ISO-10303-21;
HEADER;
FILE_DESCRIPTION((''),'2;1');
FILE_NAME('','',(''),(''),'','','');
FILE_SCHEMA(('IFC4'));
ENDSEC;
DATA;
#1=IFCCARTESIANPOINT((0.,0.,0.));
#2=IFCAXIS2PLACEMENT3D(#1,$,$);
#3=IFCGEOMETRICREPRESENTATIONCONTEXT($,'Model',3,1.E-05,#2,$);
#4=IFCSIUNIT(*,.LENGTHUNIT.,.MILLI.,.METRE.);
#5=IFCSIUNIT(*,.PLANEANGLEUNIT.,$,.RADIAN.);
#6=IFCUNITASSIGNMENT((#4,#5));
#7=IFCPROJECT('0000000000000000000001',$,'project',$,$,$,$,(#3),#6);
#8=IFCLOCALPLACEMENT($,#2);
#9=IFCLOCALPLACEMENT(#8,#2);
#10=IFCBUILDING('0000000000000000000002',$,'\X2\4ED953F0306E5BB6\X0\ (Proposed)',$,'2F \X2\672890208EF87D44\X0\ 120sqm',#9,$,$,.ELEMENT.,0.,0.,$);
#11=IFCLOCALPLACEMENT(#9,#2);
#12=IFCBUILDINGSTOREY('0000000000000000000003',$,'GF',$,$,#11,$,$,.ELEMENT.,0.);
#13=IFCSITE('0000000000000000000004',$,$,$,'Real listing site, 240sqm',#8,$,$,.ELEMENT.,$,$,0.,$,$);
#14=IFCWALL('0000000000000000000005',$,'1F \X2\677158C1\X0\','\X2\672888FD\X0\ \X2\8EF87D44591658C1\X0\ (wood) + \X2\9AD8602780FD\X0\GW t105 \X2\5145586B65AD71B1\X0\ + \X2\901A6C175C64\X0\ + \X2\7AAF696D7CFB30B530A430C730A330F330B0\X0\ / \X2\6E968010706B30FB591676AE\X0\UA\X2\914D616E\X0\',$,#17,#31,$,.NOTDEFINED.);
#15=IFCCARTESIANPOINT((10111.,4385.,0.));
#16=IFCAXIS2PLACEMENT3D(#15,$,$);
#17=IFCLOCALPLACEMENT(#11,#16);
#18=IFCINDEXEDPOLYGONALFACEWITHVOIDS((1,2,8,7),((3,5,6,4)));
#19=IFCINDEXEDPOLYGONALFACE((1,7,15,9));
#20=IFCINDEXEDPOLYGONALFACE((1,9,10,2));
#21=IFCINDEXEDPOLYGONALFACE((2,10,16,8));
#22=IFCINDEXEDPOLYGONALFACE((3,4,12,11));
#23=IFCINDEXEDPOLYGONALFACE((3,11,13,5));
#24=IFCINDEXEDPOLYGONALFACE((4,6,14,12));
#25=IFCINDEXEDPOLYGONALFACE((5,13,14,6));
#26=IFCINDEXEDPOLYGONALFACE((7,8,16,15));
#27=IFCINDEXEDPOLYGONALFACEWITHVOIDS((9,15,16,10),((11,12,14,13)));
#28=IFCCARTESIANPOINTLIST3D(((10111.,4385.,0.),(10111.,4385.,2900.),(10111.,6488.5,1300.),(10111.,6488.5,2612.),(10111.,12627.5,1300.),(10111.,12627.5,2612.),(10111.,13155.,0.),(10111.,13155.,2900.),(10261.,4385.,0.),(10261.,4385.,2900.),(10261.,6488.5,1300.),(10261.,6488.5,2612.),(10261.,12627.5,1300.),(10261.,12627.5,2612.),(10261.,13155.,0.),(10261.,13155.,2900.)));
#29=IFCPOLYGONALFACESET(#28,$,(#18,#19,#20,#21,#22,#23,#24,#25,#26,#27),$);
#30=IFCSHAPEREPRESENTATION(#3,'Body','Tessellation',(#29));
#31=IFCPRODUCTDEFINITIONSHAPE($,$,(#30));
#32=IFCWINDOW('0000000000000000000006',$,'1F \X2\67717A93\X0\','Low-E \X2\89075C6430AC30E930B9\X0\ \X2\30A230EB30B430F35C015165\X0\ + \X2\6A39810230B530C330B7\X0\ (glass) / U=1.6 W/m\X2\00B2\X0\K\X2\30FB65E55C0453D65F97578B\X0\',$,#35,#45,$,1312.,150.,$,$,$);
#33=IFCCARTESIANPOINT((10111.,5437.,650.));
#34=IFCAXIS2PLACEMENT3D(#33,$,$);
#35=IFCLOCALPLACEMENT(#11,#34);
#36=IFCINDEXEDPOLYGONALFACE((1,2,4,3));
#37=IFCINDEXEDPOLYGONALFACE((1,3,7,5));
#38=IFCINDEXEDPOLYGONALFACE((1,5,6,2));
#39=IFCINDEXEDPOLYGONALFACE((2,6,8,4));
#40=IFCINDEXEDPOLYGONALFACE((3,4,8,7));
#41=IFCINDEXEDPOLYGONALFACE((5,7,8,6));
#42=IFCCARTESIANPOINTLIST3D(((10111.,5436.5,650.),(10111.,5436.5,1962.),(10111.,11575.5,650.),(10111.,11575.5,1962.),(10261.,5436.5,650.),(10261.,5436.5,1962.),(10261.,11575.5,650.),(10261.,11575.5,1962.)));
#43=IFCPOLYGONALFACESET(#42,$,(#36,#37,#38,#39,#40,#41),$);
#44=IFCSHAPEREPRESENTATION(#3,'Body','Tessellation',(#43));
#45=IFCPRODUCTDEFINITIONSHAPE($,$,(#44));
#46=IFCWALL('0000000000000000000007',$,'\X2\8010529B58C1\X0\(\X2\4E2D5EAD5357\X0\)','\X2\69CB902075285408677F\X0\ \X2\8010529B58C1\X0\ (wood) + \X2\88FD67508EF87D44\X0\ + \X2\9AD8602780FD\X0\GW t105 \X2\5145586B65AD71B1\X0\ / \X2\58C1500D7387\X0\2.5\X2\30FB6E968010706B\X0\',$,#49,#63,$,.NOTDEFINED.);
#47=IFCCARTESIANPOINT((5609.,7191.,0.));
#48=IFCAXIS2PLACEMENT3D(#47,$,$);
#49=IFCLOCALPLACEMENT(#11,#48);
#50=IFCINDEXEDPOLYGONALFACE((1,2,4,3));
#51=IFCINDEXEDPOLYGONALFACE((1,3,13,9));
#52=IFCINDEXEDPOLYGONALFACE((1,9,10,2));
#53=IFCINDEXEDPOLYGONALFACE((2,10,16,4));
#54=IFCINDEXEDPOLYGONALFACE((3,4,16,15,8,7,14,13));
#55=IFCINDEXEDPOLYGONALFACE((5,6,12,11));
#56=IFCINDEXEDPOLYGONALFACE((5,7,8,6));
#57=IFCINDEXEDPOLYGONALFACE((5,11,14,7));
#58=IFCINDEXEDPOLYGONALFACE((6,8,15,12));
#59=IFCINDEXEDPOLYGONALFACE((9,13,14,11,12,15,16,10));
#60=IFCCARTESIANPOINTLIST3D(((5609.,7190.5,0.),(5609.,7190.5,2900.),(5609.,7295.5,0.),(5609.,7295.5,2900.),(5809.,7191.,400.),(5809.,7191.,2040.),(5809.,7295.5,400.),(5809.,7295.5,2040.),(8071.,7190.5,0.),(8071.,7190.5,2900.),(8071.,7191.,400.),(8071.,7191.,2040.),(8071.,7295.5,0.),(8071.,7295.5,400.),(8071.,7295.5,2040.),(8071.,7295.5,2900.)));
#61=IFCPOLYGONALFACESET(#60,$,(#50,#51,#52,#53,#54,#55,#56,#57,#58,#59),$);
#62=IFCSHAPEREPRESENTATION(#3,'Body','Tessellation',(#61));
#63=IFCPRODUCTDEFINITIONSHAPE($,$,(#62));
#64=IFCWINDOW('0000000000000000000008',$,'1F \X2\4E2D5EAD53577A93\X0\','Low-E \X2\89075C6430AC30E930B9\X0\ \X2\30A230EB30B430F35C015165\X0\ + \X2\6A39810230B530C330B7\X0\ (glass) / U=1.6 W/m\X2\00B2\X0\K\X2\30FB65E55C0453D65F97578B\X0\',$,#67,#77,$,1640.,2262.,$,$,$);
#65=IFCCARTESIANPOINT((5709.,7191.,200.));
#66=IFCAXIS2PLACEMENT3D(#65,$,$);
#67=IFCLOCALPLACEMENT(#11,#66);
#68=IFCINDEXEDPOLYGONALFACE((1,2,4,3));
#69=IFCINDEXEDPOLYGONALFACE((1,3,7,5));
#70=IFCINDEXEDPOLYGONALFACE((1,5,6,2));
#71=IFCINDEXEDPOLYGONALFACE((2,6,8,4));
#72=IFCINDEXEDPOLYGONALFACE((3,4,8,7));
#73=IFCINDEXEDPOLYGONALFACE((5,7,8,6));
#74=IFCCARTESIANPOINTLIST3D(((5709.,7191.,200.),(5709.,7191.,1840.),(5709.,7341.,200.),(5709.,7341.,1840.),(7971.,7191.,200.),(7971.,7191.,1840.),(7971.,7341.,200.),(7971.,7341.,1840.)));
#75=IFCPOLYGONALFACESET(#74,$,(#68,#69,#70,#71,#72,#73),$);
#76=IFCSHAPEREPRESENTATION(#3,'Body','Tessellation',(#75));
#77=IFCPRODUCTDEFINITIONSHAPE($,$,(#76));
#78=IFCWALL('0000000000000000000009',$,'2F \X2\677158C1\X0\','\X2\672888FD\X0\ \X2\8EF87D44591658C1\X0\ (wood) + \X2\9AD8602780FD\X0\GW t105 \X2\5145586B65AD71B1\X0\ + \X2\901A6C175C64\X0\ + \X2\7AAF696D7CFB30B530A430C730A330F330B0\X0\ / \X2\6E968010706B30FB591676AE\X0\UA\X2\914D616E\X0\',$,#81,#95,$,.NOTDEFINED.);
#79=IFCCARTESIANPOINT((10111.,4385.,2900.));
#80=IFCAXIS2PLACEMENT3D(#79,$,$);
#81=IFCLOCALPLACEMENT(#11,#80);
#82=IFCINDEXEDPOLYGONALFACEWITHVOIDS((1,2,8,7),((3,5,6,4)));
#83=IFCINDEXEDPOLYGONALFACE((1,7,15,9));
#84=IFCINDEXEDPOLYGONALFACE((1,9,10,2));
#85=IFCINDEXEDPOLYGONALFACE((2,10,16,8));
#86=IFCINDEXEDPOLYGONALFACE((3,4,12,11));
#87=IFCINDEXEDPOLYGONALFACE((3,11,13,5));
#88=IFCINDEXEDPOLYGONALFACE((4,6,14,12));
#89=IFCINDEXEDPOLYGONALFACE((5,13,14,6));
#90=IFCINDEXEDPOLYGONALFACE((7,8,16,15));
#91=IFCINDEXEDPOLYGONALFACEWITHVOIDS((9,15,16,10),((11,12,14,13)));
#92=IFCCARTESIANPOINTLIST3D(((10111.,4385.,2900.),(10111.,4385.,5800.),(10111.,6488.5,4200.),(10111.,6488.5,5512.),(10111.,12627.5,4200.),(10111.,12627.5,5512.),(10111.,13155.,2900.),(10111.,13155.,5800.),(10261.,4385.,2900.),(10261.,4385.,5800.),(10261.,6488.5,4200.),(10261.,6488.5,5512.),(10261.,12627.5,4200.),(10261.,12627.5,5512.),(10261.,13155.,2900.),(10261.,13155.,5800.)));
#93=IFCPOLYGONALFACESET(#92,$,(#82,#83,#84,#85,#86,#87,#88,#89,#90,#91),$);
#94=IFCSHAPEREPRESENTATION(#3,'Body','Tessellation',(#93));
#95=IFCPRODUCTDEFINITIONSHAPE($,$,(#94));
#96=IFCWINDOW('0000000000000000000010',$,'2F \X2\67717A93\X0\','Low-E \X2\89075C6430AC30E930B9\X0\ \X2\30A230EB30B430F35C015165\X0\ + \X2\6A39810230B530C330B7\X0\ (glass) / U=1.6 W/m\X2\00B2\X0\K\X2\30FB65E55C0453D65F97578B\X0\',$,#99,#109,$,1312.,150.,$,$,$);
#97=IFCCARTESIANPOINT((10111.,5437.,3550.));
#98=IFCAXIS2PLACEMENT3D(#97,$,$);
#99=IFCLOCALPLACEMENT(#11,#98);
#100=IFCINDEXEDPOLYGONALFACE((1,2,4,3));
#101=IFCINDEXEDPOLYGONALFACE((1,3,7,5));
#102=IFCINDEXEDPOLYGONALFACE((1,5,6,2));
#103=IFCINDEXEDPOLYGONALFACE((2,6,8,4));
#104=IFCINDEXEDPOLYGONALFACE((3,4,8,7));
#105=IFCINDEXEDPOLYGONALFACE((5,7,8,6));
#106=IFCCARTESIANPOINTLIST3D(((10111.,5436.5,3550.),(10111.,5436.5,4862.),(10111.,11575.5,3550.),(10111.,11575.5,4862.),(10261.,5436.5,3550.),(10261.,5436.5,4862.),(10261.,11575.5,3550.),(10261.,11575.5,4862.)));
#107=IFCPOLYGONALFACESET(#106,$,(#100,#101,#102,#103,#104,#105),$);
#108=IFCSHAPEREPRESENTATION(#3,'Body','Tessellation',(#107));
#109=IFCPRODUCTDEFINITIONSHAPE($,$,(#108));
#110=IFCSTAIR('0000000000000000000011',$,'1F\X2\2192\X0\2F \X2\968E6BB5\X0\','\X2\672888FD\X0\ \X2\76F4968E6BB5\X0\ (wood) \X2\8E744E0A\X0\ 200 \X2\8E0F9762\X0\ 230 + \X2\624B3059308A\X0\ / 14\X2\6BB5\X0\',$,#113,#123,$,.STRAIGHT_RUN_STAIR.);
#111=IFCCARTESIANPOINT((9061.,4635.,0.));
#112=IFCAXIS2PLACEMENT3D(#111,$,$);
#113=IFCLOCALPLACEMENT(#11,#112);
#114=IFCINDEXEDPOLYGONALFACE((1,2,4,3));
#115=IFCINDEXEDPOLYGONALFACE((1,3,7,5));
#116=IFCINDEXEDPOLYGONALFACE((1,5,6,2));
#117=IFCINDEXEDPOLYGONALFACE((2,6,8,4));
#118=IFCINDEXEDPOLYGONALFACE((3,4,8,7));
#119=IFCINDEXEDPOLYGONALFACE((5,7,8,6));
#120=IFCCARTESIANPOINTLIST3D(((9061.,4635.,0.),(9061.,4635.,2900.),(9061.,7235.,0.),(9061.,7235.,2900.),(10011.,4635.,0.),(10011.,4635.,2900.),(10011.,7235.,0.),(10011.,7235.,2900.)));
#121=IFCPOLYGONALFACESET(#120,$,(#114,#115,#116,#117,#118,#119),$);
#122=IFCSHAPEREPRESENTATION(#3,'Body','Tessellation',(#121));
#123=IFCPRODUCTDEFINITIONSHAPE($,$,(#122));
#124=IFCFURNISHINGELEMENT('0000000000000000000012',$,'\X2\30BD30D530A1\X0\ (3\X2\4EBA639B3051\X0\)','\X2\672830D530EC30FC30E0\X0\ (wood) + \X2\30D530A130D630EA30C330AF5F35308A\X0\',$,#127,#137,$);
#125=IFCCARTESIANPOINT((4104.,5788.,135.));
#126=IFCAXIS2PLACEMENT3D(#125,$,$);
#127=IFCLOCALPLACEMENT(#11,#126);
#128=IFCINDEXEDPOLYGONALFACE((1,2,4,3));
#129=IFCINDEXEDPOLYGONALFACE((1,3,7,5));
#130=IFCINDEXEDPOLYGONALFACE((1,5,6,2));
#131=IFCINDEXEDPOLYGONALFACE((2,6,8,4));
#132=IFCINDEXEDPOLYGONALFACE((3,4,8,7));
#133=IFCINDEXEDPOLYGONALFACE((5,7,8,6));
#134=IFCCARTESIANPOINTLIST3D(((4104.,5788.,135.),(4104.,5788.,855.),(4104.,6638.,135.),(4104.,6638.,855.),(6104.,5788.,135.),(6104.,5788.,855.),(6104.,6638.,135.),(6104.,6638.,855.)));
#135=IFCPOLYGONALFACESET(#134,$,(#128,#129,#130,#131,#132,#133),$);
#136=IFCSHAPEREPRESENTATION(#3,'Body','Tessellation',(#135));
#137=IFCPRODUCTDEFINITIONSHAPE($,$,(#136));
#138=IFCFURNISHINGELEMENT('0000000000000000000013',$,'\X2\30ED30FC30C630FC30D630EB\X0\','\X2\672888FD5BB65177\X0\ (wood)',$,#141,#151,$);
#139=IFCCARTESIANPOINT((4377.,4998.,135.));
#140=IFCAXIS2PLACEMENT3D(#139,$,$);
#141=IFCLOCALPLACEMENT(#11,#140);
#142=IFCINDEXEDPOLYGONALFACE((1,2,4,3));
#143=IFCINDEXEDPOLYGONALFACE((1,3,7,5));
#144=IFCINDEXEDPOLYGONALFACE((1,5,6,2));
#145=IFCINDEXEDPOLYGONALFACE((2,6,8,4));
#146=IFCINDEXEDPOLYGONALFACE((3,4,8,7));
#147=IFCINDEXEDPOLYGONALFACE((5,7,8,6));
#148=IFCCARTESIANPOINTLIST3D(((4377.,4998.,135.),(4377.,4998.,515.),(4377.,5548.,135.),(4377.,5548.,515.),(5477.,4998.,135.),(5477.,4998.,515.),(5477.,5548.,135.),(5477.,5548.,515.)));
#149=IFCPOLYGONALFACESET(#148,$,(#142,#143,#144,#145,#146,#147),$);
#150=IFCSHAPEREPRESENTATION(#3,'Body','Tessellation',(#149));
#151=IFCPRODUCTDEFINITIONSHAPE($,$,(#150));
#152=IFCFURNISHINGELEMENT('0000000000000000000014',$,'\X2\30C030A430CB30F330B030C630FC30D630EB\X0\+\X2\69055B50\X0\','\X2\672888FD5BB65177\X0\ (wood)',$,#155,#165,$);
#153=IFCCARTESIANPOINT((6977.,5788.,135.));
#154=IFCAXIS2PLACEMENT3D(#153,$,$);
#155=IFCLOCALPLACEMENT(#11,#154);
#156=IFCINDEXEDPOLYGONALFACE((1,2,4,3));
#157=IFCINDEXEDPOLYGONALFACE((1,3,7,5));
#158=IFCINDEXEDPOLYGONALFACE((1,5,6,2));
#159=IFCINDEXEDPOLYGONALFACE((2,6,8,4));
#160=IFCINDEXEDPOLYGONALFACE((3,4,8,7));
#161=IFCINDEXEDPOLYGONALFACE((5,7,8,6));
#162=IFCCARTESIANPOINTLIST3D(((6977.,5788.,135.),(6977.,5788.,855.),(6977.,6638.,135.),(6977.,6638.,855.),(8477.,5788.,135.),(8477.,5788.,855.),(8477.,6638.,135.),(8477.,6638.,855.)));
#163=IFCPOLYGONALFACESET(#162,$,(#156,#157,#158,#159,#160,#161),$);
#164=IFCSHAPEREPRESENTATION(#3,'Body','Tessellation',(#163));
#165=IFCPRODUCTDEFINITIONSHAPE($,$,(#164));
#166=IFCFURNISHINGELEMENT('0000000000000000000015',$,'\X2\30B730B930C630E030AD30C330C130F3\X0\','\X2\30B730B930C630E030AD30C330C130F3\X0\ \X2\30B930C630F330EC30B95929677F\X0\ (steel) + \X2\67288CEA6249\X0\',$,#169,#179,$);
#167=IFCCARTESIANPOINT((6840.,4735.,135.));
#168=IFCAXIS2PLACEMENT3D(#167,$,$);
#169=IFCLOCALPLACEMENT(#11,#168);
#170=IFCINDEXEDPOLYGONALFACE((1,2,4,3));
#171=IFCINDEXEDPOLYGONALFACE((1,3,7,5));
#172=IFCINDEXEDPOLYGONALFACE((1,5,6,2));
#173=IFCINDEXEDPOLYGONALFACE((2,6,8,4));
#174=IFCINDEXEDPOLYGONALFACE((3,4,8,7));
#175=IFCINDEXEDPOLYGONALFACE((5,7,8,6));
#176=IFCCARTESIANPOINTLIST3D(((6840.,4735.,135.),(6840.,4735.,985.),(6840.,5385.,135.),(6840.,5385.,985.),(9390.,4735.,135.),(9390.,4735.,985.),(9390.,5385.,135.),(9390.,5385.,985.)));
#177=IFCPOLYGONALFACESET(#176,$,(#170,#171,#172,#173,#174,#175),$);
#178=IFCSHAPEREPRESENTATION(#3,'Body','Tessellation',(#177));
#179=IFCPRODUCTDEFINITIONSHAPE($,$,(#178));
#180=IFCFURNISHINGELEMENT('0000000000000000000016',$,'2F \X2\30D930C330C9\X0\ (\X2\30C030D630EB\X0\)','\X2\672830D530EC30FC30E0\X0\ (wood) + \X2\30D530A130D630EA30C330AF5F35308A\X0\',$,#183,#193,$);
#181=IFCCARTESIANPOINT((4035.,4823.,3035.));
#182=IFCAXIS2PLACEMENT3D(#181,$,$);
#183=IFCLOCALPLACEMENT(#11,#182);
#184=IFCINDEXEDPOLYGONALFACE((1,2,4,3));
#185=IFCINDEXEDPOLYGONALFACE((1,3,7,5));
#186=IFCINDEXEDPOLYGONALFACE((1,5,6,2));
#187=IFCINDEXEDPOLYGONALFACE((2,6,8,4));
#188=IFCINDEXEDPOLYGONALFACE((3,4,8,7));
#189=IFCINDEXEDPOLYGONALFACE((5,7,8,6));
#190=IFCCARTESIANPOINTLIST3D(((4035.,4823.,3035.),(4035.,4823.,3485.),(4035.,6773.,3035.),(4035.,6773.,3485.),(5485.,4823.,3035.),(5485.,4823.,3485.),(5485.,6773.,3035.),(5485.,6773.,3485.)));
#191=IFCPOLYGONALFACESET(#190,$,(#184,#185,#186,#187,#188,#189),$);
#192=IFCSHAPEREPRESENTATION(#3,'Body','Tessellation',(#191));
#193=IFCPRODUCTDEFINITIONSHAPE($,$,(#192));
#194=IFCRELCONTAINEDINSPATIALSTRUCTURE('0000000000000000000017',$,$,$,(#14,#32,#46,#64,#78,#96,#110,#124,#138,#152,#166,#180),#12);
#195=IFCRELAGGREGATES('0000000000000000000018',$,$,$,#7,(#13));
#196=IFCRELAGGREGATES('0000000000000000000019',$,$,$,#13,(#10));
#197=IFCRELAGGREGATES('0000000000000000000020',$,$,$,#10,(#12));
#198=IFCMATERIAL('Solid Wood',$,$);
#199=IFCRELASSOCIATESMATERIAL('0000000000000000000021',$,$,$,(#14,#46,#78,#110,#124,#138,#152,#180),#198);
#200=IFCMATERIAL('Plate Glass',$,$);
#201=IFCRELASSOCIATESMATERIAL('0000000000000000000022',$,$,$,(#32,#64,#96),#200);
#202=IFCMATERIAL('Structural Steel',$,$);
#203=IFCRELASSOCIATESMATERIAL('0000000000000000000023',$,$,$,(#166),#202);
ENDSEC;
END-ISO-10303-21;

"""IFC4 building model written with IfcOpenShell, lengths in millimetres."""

from ifc_helpers import new_model, si_unit, frame, frame_2d, origin, place, context, project, spatial, rectangle, extrude, material, element, fill, save


model = new_model("IFC4")

# Units and contexts
model_context = context("Model", 3, precision=1e-05, world=origin())
ifc_project = project(units=[si_unit("LENGTHUNIT", "METRE", prefix="MILLI"), si_unit("PLANEANGLEUNIT", "RADIAN")], contexts=[model_context])

# Site, building, storey
site_placement = place(None, origin())
site = spatial("IfcSite", under=ifc_project, at=site_placement, ObjectType="Real listing site, 240sqm", CompositionType="ELEMENT", RefElevation=0.0)
building_placement = place(site_placement, origin())
building = spatial("IfcBuilding", under=site, at=building_placement, Name="仙台の家 (Proposed)", ObjectType="2F 木造軸組 120sqm", CompositionType="ELEMENT", ElevationOfRefHeight=0.0, ElevationOfTerrain=0.0)
storey_placement = place(building_placement, origin())
storey = spatial("IfcBuildingStorey", under=building, at=storey_placement, Name="GF", CompositionType="ELEMENT", Elevation=0.0)

# Shared definitions
ifc_material_1 = material(Name="Solid Wood")

# Walls, openings, windows
wall_1_placement = place(storey_placement, frame((10111.0, 4385.0, 0.0)))
wall_1 = element("IfcWall", 1, at=wall_1_placement, inside=storey, material=ifc_material_1, Name="1F 東壁", Description="木製 軸組外壁 (wood) + 高性能GW t105 充填断熱 + 通気層 + 窯業系サイディング / 準耐火・外皮UA配慮", PredefinedType="NOTDEFINED", context=model_context, shape_type="SweptSolid", body=[
    extrude(rectangle(XDim=150.0, YDim=8770.0, at=frame_2d((75.0, 4385.0))), frame((10111.0, 4385.0, 0.0)), (0.0, 0.0, 1.0), 2900.0),
])
opening_1_placement = place(storey_placement, frame((10111.0, 5437.0, 650.0)))
opening_1 = element("IfcOpeningElement", 2, at=opening_1_placement, cuts=wall_1, PredefinedType="NOTDEFINED", context=model_context, shape_type="SweptSolid", body=[
    extrude(rectangle(XDim=150.0, YDim=6139.0, at=frame_2d((75.0, 3069.0))), frame((10111.0, 5437.0, 650.0)), (0.0, 0.0, 1.0), 1312.0),
])
ifc_material_2 = material(Name="Plate Glass")
window_1_placement = place(storey_placement, frame((10111.0, 5437.0, 650.0)))
window_1 = element("IfcWindow", 3, at=window_1_placement, inside=storey, material=ifc_material_2, Name="1F 東窓", Description="Low-E 複層ガラス アルゴン封入 + 樹脂サッシ (glass) / U=1.6 W/m²K・日射取得型", OverallHeight=1312.0, OverallWidth=150.0, context=model_context, shape_type="SweptSolid", body=[
    extrude(rectangle(XDim=150.0, YDim=6139.0, at=frame_2d((75.0, 3069.0))), frame((10111.0, 5437.0, 650.0)), (0.0, 0.0, 1.0), 1312.0),
])
fill(opening_1, window_1)
wall_2_placement = place(storey_placement, frame((5609.0, 7191.0, 0.0)))
wall_2 = element("IfcWall", 4, at=wall_2_placement, inside=storey, material=ifc_material_1, Name="耐力壁(中庭南)", Description="構造用合板 耐力壁 (wood) + 製材軸組 + 高性能GW t105 充填断熱 / 壁倍率2.5・準耐火", PredefinedType="NOTDEFINED", context=model_context, shape_type="SweptSolid", body=[
    extrude(rectangle(XDim=2462.0, YDim=105.0, at=frame_2d((1231.0, 52.0))), frame((5609.0, 7191.0, 0.0)), (0.0, 0.0, 1.0), 2900.0),
])
opening_2_placement = place(storey_placement, frame((5709.0, 7191.0, 200.0)))
opening_2 = element("IfcOpeningElement", 5, at=opening_2_placement, cuts=wall_2, PredefinedType="NOTDEFINED", context=model_context, shape_type="SweptSolid", body=[
    extrude(rectangle(XDim=2262.0, YDim=150.0, at=frame_2d((1131.0, 75.0))), frame((5709.0, 7191.0, 200.0)), (0.0, 0.0, 1.0), 1640.0),
])
window_2_placement = place(storey_placement, frame((5709.0, 7191.0, 200.0)))
window_2 = element("IfcWindow", 6, at=window_2_placement, inside=storey, material=ifc_material_2, Name="1F 中庭南窓", Description="Low-E 複層ガラス アルゴン封入 + 樹脂サッシ (glass) / U=1.6 W/m²K・日射取得型", OverallHeight=1640.0, OverallWidth=2262.0, context=model_context, shape_type="SweptSolid", body=[
    extrude(rectangle(XDim=2262.0, YDim=150.0, at=frame_2d((1131.0, 75.0))), frame((5709.0, 7191.0, 200.0)), (0.0, 0.0, 1.0), 1640.0),
])
fill(opening_2, window_2)

# Wall, opening, window
wall_3_placement = place(storey_placement, frame((10111.0, 4385.0, 2900.0)))
wall_3 = element("IfcWall", 7, at=wall_3_placement, inside=storey, material=ifc_material_1, Name="2F 東壁", Description="木製 軸組外壁 (wood) + 高性能GW t105 充填断熱 + 通気層 + 窯業系サイディング / 準耐火・外皮UA配慮", PredefinedType="NOTDEFINED", context=model_context, shape_type="SweptSolid", body=[
    extrude(rectangle(XDim=150.0, YDim=8770.0, at=frame_2d((75.0, 4385.0))), frame((10111.0, 4385.0, 2900.0)), (0.0, 0.0, 1.0), 2900.0),
])
opening_3_placement = place(storey_placement, frame((10111.0, 5437.0, 3550.0)))
opening_3 = element("IfcOpeningElement", 8, at=opening_3_placement, cuts=wall_3, PredefinedType="NOTDEFINED", context=model_context, shape_type="SweptSolid", body=[
    extrude(rectangle(XDim=150.0, YDim=6139.0, at=frame_2d((75.0, 3069.0))), frame((10111.0, 5437.0, 3550.0)), (0.0, 0.0, 1.0), 1312.0),
])
window_3_placement = place(storey_placement, frame((10111.0, 5437.0, 3550.0)))
window_3 = element("IfcWindow", 9, at=window_3_placement, inside=storey, material=ifc_material_2, Name="2F 東窓", Description="Low-E 複層ガラス アルゴン封入 + 樹脂サッシ (glass) / U=1.6 W/m²K・日射取得型", OverallHeight=1312.0, OverallWidth=150.0, context=model_context, shape_type="SweptSolid", body=[
    extrude(rectangle(XDim=150.0, YDim=6139.0, at=frame_2d((75.0, 3069.0))), frame((10111.0, 5437.0, 3550.0)), (0.0, 0.0, 1.0), 1312.0),
])
fill(opening_3, window_3)

# Stair
stair_placement = place(storey_placement, frame((9061.0, 4635.0, 0.0)))
element("IfcStair", 10, at=stair_placement, inside=storey, material=ifc_material_1, Name="1F→2F 階段", Description="木製 直階段 (wood) 蹴上 200 踏面 230 + 手すり / 14段", PredefinedType="STRAIGHT_RUN_STAIR", context=model_context, shape_type="SweptSolid", body=[
    extrude(rectangle(XDim=950.0, YDim=2600.0, at=frame_2d((475.0, 1300.0))), frame((9061.0, 4635.0, 0.0)), (0.0, 0.0, 1.0), 2900.0),
])

# Furnishing elements
furnishing_1_placement = place(storey_placement, frame((4104.0, 5788.0, 135.0)))
element("IfcFurnishingElement", 11, at=furnishing_1_placement, inside=storey, material=ifc_material_1, Name="ソファ (3人掛け)", Description="木フレーム (wood) + ファブリック張り", context=model_context, shape_type="SweptSolid", body=[
    extrude(rectangle(XDim=2000.0, YDim=850.0, at=frame_2d((1000.0, 425.0))), frame((4104.0, 5788.0, 135.0)), (0.0, 0.0, 1.0), 720.0),
])
furnishing_2_placement = place(storey_placement, frame((4377.0, 4998.0, 135.0)))
element("IfcFurnishingElement", 12, at=furnishing_2_placement, inside=storey, material=ifc_material_1, Name="ローテーブル", Description="木製家具 (wood)", context=model_context, shape_type="SweptSolid", body=[
    extrude(rectangle(XDim=1100.0, YDim=550.0, at=frame_2d((550.0, 275.0))), frame((4377.0, 4998.0, 135.0)), (0.0, 0.0, 1.0), 380.0),
])
furnishing_3_placement = place(storey_placement, frame((6977.0, 5788.0, 135.0)))
element("IfcFurnishingElement", 13, at=furnishing_3_placement, inside=storey, material=ifc_material_1, Name="ダイニングテーブル+椅子", Description="木製家具 (wood)", context=model_context, shape_type="SweptSolid", body=[
    extrude(rectangle(XDim=1500.0, YDim=850.0, at=frame_2d((750.0, 425.0))), frame((6977.0, 5788.0, 135.0)), (0.0, 0.0, 1.0), 720.0),
])
ifc_material_3 = material(Name="Structural Steel")
furnishing_4_placement = place(storey_placement, frame((6840.0, 4735.0, 135.0)))
element("IfcFurnishingElement", 14, at=furnishing_4_placement, inside=storey, material=ifc_material_3, Name="システムキッチン", Description="システムキッチン ステンレス天板 (steel) + 木質扉", context=model_context, shape_type="SweptSolid", body=[
    extrude(rectangle(XDim=2550.0, YDim=650.0, at=frame_2d((1275.0, 325.0))), frame((6840.0, 4735.0, 135.0)), (0.0, 0.0, 1.0), 850.0),
])
furnishing_5_placement = place(storey_placement, frame((4035.0, 4823.0, 3035.0)))
element("IfcFurnishingElement", 15, at=furnishing_5_placement, inside=storey, material=ifc_material_1, Name="2F ベッド (ダブル)", Description="木フレーム (wood) + ファブリック張り", context=model_context, shape_type="SweptSolid", body=[
    extrude(rectangle(XDim=1450.0, YDim=1950.0, at=frame_2d((725.0, 975.0))), frame((4035.0, 4823.0, 3035.0)), (0.0, 0.0, 1.0), 450.0),
])

save(model, "model.ifc")
